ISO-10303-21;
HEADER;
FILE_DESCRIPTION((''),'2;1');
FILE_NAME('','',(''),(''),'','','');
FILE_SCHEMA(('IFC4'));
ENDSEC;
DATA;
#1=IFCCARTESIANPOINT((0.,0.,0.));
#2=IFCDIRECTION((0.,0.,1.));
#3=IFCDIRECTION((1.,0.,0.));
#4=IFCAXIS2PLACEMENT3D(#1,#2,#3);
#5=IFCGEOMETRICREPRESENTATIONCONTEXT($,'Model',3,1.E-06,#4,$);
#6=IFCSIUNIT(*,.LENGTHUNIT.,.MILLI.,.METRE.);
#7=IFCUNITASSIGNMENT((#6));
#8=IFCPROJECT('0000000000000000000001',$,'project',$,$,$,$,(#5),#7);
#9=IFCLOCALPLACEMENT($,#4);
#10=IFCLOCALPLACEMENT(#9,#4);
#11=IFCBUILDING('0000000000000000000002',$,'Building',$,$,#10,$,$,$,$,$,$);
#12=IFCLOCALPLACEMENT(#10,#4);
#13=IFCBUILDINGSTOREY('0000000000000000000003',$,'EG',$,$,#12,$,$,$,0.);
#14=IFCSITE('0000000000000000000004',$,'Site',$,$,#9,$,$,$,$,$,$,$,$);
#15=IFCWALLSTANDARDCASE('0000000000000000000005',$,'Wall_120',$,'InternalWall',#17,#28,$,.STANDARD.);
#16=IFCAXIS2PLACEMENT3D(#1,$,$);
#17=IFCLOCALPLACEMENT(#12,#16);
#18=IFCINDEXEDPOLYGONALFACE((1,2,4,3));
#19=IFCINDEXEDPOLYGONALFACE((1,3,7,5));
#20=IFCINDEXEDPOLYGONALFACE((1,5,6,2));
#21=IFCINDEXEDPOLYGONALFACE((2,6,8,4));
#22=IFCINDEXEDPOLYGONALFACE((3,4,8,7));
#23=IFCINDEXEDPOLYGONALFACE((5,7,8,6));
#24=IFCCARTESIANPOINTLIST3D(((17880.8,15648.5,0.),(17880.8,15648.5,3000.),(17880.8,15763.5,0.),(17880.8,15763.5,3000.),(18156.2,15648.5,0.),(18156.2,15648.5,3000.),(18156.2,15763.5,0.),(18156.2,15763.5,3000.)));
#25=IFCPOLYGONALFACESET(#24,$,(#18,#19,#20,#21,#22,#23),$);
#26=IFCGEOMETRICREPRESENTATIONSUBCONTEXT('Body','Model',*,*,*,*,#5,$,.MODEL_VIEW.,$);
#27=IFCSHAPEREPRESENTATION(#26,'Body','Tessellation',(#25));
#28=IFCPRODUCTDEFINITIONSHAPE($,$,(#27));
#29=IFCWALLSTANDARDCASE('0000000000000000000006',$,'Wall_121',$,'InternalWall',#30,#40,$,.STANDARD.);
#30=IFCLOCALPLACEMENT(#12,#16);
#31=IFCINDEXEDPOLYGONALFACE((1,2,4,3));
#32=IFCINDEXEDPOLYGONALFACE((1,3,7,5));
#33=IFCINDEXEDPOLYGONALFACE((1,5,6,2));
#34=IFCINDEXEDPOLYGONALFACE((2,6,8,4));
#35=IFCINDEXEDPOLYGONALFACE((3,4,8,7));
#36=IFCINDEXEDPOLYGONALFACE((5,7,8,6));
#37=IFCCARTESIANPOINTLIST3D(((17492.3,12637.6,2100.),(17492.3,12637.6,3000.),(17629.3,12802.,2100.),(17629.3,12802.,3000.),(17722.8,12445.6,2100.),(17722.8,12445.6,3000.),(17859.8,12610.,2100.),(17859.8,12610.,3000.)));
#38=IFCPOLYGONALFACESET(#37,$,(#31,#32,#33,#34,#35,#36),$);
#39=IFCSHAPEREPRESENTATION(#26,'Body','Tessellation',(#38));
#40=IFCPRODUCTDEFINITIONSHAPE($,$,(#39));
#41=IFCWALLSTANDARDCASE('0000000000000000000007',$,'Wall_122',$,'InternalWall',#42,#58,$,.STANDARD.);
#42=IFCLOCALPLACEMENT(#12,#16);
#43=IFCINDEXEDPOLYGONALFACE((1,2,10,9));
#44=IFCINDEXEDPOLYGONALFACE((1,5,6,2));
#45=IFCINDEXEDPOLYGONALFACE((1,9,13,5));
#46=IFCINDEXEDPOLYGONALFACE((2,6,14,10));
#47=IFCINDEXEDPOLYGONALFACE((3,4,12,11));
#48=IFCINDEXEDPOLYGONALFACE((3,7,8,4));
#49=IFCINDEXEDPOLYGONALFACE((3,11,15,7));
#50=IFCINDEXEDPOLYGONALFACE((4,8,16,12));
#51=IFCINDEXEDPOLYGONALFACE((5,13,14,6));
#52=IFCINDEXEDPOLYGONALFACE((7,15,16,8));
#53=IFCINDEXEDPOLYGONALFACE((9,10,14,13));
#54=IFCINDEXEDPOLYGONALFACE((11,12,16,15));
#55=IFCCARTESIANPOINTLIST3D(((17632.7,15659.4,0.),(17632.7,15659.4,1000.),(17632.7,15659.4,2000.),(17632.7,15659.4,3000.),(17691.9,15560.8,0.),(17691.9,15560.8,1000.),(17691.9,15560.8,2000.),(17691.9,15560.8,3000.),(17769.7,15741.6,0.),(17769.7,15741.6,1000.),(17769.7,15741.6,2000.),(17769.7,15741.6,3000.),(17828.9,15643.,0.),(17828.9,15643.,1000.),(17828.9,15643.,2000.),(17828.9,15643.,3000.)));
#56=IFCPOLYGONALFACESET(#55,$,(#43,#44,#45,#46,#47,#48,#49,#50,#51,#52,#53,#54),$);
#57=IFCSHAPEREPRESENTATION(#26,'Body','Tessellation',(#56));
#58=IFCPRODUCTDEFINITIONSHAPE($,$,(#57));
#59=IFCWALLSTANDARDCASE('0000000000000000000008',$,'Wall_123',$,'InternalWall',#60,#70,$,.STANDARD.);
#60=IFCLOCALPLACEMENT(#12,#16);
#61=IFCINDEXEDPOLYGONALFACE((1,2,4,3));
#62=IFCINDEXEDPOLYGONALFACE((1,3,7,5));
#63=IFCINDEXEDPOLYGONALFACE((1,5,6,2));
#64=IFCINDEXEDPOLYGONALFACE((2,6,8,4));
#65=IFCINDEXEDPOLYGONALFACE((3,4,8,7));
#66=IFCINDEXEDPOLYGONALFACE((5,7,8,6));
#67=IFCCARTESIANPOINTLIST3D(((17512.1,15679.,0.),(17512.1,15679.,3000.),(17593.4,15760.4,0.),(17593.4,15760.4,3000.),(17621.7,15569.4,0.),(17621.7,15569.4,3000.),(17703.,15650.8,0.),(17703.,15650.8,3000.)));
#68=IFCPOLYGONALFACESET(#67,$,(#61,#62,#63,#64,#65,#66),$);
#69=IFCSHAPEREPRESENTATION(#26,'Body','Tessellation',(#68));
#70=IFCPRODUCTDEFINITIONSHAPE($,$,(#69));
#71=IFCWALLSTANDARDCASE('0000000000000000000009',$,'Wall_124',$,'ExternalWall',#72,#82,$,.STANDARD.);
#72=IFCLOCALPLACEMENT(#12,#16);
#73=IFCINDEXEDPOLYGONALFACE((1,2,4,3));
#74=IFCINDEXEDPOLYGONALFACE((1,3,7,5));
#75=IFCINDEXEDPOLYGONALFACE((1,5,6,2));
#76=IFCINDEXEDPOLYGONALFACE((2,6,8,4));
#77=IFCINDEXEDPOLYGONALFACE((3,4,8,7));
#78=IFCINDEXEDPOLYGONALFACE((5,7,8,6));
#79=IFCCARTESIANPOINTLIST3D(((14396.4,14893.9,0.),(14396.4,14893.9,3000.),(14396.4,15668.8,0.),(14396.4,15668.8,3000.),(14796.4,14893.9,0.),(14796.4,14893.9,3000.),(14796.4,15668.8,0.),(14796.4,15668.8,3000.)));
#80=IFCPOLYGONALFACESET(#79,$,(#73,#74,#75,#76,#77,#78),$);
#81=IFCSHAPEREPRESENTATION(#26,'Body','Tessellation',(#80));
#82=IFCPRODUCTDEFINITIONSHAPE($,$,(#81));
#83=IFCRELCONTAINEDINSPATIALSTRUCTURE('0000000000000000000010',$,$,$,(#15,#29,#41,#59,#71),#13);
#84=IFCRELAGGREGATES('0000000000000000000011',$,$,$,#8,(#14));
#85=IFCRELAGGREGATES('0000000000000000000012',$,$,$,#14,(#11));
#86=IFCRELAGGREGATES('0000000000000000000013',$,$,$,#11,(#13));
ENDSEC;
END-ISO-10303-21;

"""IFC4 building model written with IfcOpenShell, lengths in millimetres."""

from ifc_helpers import new_model, si_unit, frame, origin_with_axes, place, context, subcontext, project, spatial, rectangle, extrude, element, save


model = new_model("IFC4")

# Units and contexts
model_context = context("Model", 3, precision=1e-06, world=origin_with_axes())
body_context = subcontext(model_context, "Body", "Model", "MODEL_VIEW")
ifc_project = project(units=[si_unit("LENGTHUNIT", "METRE", prefix="MILLI")], contexts=[model_context])

# Site, building, storey
site_placement = place(None, origin_with_axes())
site = spatial("IfcSite", under=ifc_project, at=site_placement, Name="Site")
building_placement = place(site_placement, origin_with_axes())
building = spatial("IfcBuilding", under=site, at=building_placement, Name="Building")
storey_placement = place(building_placement, origin_with_axes())
storey = spatial("IfcBuildingStorey", under=building, at=storey_placement, Name="EG", Elevation=0.0)

# Wall
wall_1_placement = place(storey_placement, origin_with_axes())
element("IfcWallStandardCase", 1, at=wall_1_placement, inside=storey, Name="Wall_120", ObjectType="InternalWall", PredefinedType="STANDARD", context=body_context, shape_type="SweptSolid", body=[
    extrude(rectangle(XDim=275.3, YDim=115.0), frame((18018.5, 15706.0, 0.0), z_axis=(0.0, 0.0, 1.0), x_axis=(1.0, 0.0, 0.0)), (0.0, 0.0, 1.0), 3000.0),
])

# Walls, openings
wall_2_placement = place(storey_placement, origin_with_axes())
wall_2 = element("IfcWallStandardCase", 2, at=wall_2_placement, inside=storey, Name="Wall_121", ObjectType="InternalWall", PredefinedType="STANDARD", context=body_context, shape_type="SweptSolid", body=[
    extrude(rectangle(XDim=214.0, YDim=300.0), frame((17676.0, 12623.8, 0.0), z_axis=(0.0, 0.0, 1.0), x_axis=(-0.640184, -0.768221, 0.0)), (0.0, 0.0, 1.0), 3000.0),
])
opening_1_placement = place(wall_2_placement, origin_with_axes())
element("IfcOpeningElement", 3, at=opening_1_placement, inside=storey, cuts=wall_2, context=body_context, shape_type="SweptSolid", body=[
    extrude(rectangle(XDim=1421.0, YDim=300.0), frame((17537.8, 12457.9, 0.0), z_axis=(0.0, 0.0, 1.0), x_axis=(-0.640184, -0.768221, 0.0)), (0.0, 0.0, 1.0), 2100.0),
])
wall_3_placement = place(storey_placement, origin_with_axes())
wall_3 = element("IfcWallStandardCase", 4, at=wall_3_placement, inside=storey, Name="Wall_122", ObjectType="InternalWall", PredefinedType="STANDARD", context=body_context, shape_type="SweptSolid", body=[
    extrude(rectangle(XDim=159.8, YDim=115.0), frame((17730.8, 15651.2, 0.0), z_axis=(0.0, 0.0, 1.0), x_axis=(0.857493, 0.514496, 0.0)), (0.0, 0.0, 1.0), 3000.0),
])
opening_2_placement = place(wall_3_placement, origin_with_axes())
element("IfcOpeningElement", 5, at=opening_2_placement, inside=storey, cuts=wall_3, context=body_context, shape_type="SweptSolid", body=[
    extrude(rectangle(XDim=2700.4, YDim=115.0), frame((18005.0, 15815.7, 1000.0), z_axis=(0.0, 0.0, 1.0), x_axis=(0.857493, 0.514496, 0.0)), (0.0, 0.0, 1.0), 1000.0),
])

# Walls
wall_4_placement = place(storey_placement, origin_with_axes())
element("IfcWallStandardCase", 6, at=wall_4_placement, inside=storey, Name="Wall_123", ObjectType="InternalWall", PredefinedType="STANDARD", context=body_context, shape_type="SweptSolid", body=[
    extrude(rectangle(XDim=155.0, YDim=115.0), frame((17607.5, 15664.9, 0.0), z_axis=(0.0, 0.0, 1.0), x_axis=(-0.707107, 0.707107, 0.0)), (0.0, 0.0, 1.0), 3000.0),
])
wall_5_placement = place(storey_placement, origin_with_axes())
element("IfcWallStandardCase", 7, at=wall_5_placement, inside=storey, Name="Wall_124", ObjectType="ExternalWall", PredefinedType="STANDARD", context=body_context, shape_type="SweptSolid", body=[
    extrude(rectangle(XDim=774.9, YDim=400.0), frame((14596.4, 15281.3, 0.0), z_axis=(0.0, 0.0, 1.0), x_axis=(0.0, 1.0, 0.0)), (0.0, 0.0, 1.0), 3000.0),
])

save(model, "model.ifc")
